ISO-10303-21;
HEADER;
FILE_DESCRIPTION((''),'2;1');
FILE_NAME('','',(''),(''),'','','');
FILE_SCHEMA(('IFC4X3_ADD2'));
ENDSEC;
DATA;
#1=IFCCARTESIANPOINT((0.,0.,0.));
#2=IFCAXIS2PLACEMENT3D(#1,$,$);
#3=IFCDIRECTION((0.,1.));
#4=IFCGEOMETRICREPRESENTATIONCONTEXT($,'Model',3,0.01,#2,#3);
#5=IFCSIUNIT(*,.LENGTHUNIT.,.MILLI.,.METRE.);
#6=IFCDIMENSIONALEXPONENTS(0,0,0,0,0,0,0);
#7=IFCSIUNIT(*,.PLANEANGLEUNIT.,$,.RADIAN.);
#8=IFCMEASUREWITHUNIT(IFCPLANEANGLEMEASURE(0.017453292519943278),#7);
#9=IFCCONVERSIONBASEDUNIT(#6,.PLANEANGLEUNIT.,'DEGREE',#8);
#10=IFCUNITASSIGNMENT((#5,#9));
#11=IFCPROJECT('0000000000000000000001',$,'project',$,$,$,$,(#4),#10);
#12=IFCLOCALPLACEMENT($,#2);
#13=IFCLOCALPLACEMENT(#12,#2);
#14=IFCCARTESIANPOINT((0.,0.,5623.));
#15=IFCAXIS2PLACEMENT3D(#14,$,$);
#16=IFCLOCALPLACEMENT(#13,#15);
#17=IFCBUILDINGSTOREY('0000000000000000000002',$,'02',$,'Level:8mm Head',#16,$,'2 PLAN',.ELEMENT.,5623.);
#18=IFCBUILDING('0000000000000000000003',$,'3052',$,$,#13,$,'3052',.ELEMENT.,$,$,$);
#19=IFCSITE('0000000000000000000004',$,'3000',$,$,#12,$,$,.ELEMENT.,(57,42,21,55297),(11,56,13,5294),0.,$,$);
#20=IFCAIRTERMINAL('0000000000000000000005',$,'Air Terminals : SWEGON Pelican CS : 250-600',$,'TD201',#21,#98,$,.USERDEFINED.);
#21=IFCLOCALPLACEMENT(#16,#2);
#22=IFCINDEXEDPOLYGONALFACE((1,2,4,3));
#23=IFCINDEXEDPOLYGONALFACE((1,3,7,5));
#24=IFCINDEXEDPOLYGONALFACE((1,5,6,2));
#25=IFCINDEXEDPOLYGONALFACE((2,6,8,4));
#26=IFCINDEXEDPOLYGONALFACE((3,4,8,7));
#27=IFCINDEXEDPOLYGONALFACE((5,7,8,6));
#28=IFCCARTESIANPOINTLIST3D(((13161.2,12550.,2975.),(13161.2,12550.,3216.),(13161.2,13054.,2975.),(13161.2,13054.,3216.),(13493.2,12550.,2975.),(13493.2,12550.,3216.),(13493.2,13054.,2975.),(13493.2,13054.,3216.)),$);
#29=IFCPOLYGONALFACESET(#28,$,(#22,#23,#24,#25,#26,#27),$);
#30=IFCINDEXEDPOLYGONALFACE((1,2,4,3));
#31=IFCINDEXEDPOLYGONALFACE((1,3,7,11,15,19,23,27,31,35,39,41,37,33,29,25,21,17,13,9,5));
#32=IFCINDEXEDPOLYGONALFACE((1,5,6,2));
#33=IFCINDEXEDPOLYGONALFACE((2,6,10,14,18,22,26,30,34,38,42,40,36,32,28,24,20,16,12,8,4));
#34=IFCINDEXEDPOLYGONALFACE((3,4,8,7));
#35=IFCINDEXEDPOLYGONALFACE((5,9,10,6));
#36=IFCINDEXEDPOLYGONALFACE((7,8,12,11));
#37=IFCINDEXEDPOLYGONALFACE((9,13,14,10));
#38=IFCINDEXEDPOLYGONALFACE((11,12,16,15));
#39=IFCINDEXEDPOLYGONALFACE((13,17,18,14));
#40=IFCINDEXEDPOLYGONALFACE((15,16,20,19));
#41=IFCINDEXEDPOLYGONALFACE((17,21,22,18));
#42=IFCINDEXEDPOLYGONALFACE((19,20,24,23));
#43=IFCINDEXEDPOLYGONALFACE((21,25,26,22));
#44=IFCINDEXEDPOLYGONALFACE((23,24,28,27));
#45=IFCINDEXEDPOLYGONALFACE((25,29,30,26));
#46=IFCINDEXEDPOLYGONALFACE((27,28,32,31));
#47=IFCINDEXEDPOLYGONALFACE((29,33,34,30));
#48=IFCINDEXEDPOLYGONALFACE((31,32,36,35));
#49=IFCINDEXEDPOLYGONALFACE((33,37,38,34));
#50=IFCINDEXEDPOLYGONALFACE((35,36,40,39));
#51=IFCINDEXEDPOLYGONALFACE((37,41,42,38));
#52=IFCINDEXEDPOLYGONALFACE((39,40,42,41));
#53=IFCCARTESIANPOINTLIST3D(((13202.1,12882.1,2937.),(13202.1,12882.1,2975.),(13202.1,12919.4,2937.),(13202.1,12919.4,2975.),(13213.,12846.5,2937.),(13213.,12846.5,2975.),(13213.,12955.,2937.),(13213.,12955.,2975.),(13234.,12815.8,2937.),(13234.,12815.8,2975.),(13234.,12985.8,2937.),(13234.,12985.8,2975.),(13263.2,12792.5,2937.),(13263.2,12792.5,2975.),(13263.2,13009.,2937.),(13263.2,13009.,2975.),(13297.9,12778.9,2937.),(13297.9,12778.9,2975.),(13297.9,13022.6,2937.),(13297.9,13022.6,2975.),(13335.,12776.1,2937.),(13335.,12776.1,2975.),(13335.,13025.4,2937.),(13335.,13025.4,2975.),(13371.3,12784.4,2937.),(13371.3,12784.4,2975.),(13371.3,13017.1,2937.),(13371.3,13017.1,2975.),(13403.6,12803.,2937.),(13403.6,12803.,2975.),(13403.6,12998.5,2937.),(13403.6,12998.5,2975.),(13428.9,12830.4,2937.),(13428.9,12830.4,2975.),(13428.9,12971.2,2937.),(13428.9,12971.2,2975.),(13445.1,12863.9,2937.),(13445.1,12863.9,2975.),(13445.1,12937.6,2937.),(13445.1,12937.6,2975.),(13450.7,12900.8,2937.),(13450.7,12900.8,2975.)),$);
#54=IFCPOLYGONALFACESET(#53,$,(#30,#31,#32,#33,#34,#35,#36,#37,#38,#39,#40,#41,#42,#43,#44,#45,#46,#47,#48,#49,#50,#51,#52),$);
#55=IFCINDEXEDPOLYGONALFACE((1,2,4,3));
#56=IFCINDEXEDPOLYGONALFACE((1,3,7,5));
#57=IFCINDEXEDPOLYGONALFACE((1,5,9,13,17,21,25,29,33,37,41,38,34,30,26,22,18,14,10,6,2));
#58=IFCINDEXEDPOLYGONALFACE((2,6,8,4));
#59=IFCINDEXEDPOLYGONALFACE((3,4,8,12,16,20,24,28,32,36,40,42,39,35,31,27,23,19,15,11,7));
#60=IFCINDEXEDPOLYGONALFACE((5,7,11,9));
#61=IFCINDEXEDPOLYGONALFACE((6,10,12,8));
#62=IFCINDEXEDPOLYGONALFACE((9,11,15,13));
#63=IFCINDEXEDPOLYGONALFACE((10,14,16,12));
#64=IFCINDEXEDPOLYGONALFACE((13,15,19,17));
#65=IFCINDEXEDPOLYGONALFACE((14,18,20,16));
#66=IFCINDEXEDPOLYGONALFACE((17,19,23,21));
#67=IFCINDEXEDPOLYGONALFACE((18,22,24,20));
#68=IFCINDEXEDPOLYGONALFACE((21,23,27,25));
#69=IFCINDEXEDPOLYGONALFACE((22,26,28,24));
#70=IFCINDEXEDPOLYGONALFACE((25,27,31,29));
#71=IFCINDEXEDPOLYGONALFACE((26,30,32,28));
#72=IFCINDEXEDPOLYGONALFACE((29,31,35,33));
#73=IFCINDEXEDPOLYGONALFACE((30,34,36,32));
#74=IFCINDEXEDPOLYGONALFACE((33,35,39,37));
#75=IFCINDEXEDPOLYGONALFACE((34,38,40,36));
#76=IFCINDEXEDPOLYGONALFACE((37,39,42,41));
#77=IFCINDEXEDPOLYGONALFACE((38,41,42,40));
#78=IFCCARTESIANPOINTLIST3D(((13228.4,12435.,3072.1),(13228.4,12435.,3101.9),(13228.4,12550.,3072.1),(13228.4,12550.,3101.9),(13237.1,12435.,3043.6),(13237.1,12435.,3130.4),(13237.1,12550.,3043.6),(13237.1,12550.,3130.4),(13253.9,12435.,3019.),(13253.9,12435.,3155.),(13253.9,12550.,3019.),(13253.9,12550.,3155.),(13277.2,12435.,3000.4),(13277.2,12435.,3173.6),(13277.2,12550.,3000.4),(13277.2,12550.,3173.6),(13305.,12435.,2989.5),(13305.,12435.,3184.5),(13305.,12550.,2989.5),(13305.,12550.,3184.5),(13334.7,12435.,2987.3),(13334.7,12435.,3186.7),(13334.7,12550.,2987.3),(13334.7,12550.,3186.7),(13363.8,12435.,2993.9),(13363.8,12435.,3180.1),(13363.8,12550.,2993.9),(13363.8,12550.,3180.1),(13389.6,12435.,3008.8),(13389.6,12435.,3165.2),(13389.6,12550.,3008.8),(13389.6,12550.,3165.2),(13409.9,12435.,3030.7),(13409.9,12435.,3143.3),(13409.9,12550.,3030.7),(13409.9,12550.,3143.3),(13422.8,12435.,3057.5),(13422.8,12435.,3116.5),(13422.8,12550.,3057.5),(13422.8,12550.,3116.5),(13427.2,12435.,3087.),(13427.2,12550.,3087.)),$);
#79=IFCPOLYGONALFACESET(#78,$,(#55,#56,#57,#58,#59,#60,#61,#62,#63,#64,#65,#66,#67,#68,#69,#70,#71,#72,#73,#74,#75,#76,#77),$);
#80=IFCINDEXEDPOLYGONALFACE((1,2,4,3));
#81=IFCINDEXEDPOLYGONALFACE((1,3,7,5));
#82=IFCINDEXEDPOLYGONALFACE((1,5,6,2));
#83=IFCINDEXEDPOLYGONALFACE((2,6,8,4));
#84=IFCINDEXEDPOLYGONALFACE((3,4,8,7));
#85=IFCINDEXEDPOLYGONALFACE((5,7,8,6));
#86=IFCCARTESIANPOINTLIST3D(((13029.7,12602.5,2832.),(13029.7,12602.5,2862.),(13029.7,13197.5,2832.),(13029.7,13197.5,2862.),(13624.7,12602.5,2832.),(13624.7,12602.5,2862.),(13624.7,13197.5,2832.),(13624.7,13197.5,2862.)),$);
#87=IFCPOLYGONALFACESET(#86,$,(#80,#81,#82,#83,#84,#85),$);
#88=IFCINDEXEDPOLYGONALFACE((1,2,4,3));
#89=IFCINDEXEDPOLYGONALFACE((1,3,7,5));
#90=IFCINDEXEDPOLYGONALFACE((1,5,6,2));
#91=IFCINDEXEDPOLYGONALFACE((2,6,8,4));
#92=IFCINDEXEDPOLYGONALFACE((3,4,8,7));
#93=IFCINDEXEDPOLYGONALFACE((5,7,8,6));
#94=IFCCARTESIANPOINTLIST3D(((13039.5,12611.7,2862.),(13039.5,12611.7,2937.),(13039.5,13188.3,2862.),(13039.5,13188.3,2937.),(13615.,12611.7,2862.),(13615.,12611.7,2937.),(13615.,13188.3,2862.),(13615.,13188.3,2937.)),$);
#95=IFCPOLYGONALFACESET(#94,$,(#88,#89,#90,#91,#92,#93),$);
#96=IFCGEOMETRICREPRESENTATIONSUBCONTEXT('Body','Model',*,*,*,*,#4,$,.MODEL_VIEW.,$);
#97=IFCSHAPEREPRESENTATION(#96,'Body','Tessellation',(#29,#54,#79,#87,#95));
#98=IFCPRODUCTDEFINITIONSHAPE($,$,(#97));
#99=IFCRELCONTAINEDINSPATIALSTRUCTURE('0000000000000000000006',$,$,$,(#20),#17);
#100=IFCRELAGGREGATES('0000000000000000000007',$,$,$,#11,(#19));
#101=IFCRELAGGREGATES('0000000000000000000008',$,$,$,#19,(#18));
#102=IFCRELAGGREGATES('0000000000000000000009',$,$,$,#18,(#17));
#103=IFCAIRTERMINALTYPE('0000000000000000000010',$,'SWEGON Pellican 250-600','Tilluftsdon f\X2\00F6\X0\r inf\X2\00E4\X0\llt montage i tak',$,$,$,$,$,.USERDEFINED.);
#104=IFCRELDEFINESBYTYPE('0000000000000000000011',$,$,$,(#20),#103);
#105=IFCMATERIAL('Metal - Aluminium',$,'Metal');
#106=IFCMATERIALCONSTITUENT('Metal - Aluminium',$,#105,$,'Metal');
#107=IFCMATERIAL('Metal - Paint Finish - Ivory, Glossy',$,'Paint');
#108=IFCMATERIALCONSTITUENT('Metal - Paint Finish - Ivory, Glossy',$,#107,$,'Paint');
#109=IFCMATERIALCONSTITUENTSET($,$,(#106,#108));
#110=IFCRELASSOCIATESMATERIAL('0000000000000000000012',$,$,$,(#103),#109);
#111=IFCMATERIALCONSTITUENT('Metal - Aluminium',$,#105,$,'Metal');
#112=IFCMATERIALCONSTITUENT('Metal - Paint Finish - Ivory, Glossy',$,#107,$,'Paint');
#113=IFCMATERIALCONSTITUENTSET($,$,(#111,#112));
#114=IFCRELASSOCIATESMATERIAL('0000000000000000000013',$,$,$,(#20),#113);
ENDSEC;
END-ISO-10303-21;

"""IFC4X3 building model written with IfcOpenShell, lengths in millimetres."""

from ifc_helpers import new_model, entity, si_unit, converted_unit, direction, frame, frame_2d, origin, origin_2d_with_axis, place, context, subcontext, project, spatial, rectangle, circle, extrude, source, transform, mapped, material, constituent, constituent_set, type_object, type_shapes, element, save


model = new_model("IFC4X3")

# Units and contexts
model_context = context("Model", 3, precision=0.01, world=origin(), true_north=direction((0.0, 1.0)))
body_context = subcontext(model_context, "Body", "Model", "MODEL_VIEW")
ifc_project = project(units=[si_unit("LENGTHUNIT", "METRE", prefix="MILLI"), converted_unit("PLANEANGLEUNIT", "DEGREE", entity("IfcPlaneAngleMeasure", 0.017453292519943278), si_unit("PLANEANGLEUNIT", "RADIAN"), dimensions=[0, 0, 0, 0, 0, 0, 0])], contexts=[model_context])

# Site, building, storey
site_placement = place(None, origin())
site = spatial("IfcSite", under=ifc_project, at=site_placement, Name="3000", CompositionType="ELEMENT", RefLatitude=(57, 42, 21, 55297), RefLongitude=(11, 56, 13, 5294), RefElevation=0.0)
building_placement = place(site_placement, origin())
building = spatial("IfcBuilding", under=site, at=building_placement, Name="3052", LongName="3052", CompositionType="ELEMENT")
storey_placement = place(building_placement, frame((0.0, 0.0, 5623.0)))
storey = spatial("IfcBuildingStorey", under=building, at=storey_placement, Name="02", ObjectType="Level:8mm Head", LongName="2 PLAN", CompositionType="ELEMENT", Elevation=5623.0)

# Air terminal
ifc_material_1 = material(Name="Metal - Aluminium", Category="Metal")
ifc_material_2 = material(Name="Metal - Paint Finish - Ivory, Glossy", Category="Paint")
ifc_constituent_1 = constituent(ifc_material_1, Name="Metal - Aluminium", Category="Metal")
ifc_constituent_2 = constituent(ifc_material_2, Name="Metal - Paint Finish - Ivory, Glossy", Category="Paint")
ifc_constituent_set_1 = constituent_set(constituents=[ifc_constituent_1, ifc_constituent_2])
air_terminal_type_1 = type_object("IfcAirTerminalType", Name="SWEGON Pellican 250-600", Description="Tilluftsdon för infällt montage i tak", PredefinedType="USERDEFINED", material=ifc_constituent_set_1)
shared_shape_1 = source(origin(), body_context, "Body", "SweptSolid", [
    extrude(rectangle(XDim=332.0, YDim=504.0, at=origin_2d_with_axis()), frame((0.0, 98.0, -354.0), z_axis=(0.0, 0.0, 1.0), x_axis=(-1.0, 0.0, 0.0)), (0.0, 0.0, 1.0), 241.0),
    extrude(circle(Radius=125.0, at=frame_2d((0.0, 0.0), x_axis=(1.0, 0.0))), frame((-1.6, -0.8, -113.0)), (0.0, 0.0, 1.0), 38.0),
    extrude(circle(Radius=100.0, at=frame_2d((0.0, 0.0), x_axis=(1.0, 0.0))), frame((0.0, 350.0, -225.0), z_axis=(0.0, 1.0, 0.0), x_axis=(1.0, 0.0, 0.0)), (0.0, 0.0, 1.0), 115.0),
    extrude(rectangle(XDim=595.0, YDim=595.0, at=frame_2d((0.0, 0.0), x_axis=(1.0, 0.0))), frame((0.0, 0.0, 0.0), z_axis=(0.0, 0.0, 1.0), x_axis=(-1.0, 0.0, 0.0)), (0.0, 0.0, 1.0), 30.0),
    extrude(rectangle(XDim=575.5, YDim=576.5, at=origin_2d_with_axis()), frame((0.0, 0.0, -75.0), z_axis=(0.0, 0.0, 1.0), x_axis=(-1.0, 0.0, 0.0)), (0.0, 0.0, 1.0), 75.0),
])
type_shapes(air_terminal_type_1, [shared_shape_1])
ifc_constituent_3 = constituent(ifc_material_1, Name="Metal - Aluminium", Category="Metal")
ifc_constituent_4 = constituent(ifc_material_2, Name="Metal - Paint Finish - Ivory, Glossy", Category="Paint")
ifc_constituent_set_2 = constituent_set(constituents=[ifc_constituent_3, ifc_constituent_4])
air_terminal_1_placement = place(storey_placement, frame((13327.2, 12900.0, 2862.0), z_axis=(0.0, 0.0, -1.0), x_axis=(1.0, 0.0, 0.0)))
element("IfcAirTerminal", 1, at=air_terminal_1_placement, inside=storey, type_object=air_terminal_type_1, material=ifc_constituent_set_2, Name="Air Terminals : SWEGON Pelican CS : 250-600", ObjectType="TD201", PredefinedType="USERDEFINED", context=body_context, shape_type="MappedRepresentation", body=[
    mapped(shared_shape_1, transform((0.0, 0.0, 0.0), scale=1.0)),
])

save(model, "model.ifc")
